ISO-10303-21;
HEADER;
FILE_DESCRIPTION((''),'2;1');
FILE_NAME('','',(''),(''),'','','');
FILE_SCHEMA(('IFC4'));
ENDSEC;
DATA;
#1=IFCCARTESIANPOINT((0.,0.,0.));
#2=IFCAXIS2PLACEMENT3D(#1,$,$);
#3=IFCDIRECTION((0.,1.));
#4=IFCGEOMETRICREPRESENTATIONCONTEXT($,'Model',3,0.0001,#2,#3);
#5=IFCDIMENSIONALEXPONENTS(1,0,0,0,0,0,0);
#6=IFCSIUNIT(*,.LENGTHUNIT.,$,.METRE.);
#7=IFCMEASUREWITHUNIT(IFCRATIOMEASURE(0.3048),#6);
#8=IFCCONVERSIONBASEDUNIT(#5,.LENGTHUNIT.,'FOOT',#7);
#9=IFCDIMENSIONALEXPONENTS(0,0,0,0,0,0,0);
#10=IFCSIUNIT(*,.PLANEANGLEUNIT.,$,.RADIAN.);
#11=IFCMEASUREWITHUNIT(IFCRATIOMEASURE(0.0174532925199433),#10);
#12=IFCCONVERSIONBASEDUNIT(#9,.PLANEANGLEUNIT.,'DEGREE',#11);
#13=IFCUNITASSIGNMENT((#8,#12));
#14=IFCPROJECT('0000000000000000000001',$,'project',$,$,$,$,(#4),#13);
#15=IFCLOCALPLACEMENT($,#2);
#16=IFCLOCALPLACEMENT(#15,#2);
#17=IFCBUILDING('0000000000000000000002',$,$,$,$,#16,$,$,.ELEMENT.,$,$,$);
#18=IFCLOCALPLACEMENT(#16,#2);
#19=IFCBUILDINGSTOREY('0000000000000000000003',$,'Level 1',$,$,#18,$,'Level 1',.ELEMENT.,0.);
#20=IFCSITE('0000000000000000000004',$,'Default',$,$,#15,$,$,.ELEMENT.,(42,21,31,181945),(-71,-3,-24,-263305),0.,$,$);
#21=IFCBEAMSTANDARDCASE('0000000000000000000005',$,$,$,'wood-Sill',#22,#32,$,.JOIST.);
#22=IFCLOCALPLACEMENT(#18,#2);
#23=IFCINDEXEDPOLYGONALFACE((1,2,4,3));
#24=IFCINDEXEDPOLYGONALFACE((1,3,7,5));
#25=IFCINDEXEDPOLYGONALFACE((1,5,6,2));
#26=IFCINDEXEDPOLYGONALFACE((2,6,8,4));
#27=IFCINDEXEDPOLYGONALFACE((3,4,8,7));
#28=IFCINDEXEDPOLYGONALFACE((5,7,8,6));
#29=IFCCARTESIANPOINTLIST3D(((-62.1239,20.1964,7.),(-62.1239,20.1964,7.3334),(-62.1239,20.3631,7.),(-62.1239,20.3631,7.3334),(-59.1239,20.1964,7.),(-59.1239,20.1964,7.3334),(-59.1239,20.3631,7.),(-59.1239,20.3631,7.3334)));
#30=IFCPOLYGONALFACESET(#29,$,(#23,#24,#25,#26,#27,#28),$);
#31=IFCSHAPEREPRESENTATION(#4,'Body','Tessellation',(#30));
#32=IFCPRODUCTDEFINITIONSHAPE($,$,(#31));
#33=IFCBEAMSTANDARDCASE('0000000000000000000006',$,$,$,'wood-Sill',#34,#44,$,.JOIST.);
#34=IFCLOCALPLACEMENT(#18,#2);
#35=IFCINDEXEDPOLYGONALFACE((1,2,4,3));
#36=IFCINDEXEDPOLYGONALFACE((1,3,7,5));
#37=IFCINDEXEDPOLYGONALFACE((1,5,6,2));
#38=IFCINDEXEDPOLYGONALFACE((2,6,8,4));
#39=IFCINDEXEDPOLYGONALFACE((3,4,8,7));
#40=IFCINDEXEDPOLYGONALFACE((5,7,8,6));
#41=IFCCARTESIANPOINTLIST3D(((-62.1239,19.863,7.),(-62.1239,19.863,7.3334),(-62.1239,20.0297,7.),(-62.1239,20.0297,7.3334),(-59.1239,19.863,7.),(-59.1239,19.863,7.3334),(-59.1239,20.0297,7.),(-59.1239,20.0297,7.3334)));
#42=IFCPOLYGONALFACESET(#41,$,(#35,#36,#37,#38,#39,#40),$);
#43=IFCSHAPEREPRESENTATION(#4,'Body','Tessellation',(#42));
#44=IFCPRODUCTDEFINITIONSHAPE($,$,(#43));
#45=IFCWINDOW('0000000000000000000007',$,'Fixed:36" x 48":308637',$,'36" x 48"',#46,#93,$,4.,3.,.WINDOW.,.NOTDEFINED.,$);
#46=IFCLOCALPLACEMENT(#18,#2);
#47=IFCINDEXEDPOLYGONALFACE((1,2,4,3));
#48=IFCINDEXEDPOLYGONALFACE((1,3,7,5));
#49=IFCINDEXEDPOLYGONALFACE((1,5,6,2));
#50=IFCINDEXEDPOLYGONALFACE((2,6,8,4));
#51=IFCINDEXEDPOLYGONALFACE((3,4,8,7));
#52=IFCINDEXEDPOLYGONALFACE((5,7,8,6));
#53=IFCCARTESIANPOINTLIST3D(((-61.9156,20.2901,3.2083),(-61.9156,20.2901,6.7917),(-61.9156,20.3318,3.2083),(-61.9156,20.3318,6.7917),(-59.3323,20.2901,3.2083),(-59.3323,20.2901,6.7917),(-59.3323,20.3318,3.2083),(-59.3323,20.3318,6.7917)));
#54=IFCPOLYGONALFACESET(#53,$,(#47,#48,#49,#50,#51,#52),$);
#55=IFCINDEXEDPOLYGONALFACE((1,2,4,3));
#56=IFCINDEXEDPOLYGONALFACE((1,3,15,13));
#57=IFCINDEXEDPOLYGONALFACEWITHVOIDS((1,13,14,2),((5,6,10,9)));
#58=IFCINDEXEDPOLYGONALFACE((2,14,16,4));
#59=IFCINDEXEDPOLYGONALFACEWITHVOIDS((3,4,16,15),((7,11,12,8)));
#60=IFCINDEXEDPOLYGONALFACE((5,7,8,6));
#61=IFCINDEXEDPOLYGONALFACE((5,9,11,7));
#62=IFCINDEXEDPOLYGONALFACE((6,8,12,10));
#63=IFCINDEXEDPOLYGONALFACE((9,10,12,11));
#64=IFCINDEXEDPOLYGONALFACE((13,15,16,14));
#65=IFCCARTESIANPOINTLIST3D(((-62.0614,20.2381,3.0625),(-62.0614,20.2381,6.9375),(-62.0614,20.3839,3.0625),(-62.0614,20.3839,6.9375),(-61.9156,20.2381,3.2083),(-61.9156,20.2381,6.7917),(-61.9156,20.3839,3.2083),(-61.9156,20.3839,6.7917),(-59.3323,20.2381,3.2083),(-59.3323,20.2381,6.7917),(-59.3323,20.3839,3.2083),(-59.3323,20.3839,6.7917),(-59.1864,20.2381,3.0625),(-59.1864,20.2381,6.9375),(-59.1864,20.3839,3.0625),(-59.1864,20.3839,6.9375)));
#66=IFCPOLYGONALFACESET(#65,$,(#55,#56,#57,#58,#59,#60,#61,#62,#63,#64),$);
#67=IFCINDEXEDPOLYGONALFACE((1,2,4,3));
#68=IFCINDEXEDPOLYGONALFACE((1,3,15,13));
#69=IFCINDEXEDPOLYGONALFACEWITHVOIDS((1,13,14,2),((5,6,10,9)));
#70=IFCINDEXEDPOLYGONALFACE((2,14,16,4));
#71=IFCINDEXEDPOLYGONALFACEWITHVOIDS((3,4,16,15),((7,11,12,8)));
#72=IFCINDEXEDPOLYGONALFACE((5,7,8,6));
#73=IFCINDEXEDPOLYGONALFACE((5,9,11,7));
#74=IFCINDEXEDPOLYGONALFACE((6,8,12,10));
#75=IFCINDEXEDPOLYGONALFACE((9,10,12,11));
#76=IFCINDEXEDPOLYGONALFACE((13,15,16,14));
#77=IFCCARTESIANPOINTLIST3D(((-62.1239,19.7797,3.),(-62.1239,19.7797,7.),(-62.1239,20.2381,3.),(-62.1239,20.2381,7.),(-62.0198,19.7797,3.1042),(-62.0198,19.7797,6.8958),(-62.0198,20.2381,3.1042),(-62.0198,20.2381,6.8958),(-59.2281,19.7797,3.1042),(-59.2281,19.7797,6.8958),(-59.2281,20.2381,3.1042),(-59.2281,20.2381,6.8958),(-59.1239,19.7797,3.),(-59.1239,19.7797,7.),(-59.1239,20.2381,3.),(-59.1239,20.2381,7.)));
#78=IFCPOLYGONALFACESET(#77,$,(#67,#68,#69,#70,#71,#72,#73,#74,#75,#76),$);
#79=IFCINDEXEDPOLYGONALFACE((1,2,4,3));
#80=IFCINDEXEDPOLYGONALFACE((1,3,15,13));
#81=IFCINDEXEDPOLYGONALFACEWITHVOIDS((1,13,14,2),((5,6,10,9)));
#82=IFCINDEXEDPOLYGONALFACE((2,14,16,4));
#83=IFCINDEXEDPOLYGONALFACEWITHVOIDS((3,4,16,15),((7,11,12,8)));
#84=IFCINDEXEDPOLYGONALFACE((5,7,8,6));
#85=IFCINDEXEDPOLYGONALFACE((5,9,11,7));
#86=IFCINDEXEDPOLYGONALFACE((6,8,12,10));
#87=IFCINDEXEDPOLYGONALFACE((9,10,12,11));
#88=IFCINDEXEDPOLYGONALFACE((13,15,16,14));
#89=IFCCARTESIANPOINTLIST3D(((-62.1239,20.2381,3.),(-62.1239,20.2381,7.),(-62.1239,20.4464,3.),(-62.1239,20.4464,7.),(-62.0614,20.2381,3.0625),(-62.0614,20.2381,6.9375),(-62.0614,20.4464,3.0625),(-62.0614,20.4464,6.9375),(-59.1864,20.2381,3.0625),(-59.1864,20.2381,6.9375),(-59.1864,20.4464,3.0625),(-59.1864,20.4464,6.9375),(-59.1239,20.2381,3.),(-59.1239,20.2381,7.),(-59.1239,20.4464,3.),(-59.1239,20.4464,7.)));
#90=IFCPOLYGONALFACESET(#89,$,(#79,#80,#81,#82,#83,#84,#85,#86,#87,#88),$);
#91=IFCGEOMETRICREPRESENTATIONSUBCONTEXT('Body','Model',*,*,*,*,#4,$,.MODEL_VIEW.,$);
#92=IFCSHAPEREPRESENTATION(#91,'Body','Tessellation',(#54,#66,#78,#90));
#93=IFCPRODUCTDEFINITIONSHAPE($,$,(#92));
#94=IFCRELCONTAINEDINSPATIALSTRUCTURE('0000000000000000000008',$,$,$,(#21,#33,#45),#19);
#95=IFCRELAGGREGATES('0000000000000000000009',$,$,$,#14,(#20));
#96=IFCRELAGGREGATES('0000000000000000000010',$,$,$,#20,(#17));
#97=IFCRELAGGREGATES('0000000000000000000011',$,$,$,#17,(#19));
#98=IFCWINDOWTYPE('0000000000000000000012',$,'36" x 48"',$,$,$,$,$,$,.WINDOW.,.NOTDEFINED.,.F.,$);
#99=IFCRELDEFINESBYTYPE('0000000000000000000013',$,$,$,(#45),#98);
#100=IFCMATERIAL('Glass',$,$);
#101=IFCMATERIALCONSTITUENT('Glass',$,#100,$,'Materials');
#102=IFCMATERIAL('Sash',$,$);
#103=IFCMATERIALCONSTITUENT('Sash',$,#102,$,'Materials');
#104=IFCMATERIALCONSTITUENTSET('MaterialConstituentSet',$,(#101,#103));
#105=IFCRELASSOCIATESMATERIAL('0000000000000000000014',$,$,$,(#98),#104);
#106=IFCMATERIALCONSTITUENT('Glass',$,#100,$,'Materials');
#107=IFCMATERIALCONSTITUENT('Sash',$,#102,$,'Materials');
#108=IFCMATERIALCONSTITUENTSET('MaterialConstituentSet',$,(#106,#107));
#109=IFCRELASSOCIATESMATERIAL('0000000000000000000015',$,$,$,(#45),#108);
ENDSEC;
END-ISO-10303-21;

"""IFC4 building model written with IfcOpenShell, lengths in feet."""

from ifc_helpers import new_model, entity, si_unit, converted_unit, direction, frame, frame_2d, origin, origin_with_axes, place, context, subcontext, project, spatial, polyline, rectangle, outline, extrude, source, transform, mapped, material, constituent, constituent_set, type_object, type_shapes, element, save


model = new_model("IFC4")

# Units and contexts
model_context = context("Model", 3, precision=0.0001, world=origin(), true_north=direction((0.0, 1.0)))
body_context = subcontext(model_context, "Body", "Model", "MODEL_VIEW")
ifc_project = project(units=[converted_unit("LENGTHUNIT", "FOOT", entity("IfcRatioMeasure", 0.3048), si_unit("LENGTHUNIT", "METRE"), dimensions=[1, 0, 0, 0, 0, 0, 0]), converted_unit("PLANEANGLEUNIT", "DEGREE", entity("IfcRatioMeasure", 0.0174532925199433), si_unit("PLANEANGLEUNIT", "RADIAN"), dimensions=[0, 0, 0, 0, 0, 0, 0])], contexts=[model_context])

# Site, building, storey
site_placement = place(None, origin())
site = spatial("IfcSite", under=ifc_project, at=site_placement, Name="Default", CompositionType="ELEMENT", RefLatitude=(42, 21, 31, 181945), RefLongitude=(-71, -3, -24, -263305), RefElevation=0.0)
building_placement = place(site_placement, origin())
building = spatial("IfcBuilding", under=site, at=building_placement, CompositionType="ELEMENT")
storey_placement = place(building_placement, origin())
storey = spatial("IfcBuildingStorey", under=building, at=storey_placement, Name="Level 1", LongName="Level 1", CompositionType="ELEMENT", Elevation=0.0)

# Shared definitions
placement_1 = place(storey_placement, frame((-69.2906, 20.1131, 0.0)))

# Beams
for number, where, z_axis, x_axis in (
    (1, (7.1667, 0.1667, 7.1667), (1.0, 0.0, 0.0), (0.0, 0.0, 1.0)),
    (2, (7.1667, -0.1667, 7.1667), (1.0, 0.0, 0.0), (0.0, 0.0, 1.0)),
):
    element("IfcBeamStandardCase", number, at=place(placement_1, frame(where, z_axis=z_axis, x_axis=x_axis)), inside=storey, ObjectType="wood-Sill", PredefinedType="JOIST", context=model_context, shape_type="SweptSolid", body=[
        extrude(rectangle(XDim=0.3333, YDim=0.1667), origin_with_axes(), (0.0, 0.0, 1.0), 3.0),
    ])

# Window
ifc_material_1 = material(Name="Glass")
ifc_constituent_1 = constituent(ifc_material_1, Name="Glass", Category="Materials")
ifc_material_2 = material(Name="Sash")
ifc_constituent_2 = constituent(ifc_material_2, Name="Sash", Category="Materials")
ifc_constituent_set_1 = constituent_set(constituents=[ifc_constituent_1, ifc_constituent_2], Name="MaterialConstituentSet")
ifc_constituent_3 = constituent(ifc_material_1, Name="Glass", Category="Materials")
ifc_constituent_4 = constituent(ifc_material_2, Name="Sash", Category="Materials")
ifc_constituent_set_2 = constituent_set(constituents=[ifc_constituent_3, ifc_constituent_4], Name="MaterialConstituentSet")
window_type = type_object("IfcWindowType", Name="36\" x 48\"", ParameterTakesPrecedence=False, PartitioningType="NOTDEFINED", PredefinedType="WINDOW", material=ifc_constituent_set_2)
shared_shape = source(origin(), body_context, "Body", "SweptSolid", [
    extrude(rectangle(XDim=0.0417, YDim=2.5833, at=frame_2d((0.0, 0.0), x_axis=(1.0, 0.0))), frame((1.5, 0.5312, 0.2083), z_axis=(0.0, 0.0, 1.0), x_axis=(0.0, 1.0, 0.0)), (0.0, 0.0, 1.0), 3.5833),
    extrude(outline(polyline([(-1.4375, -1.9375), (1.4375, -1.9375), (1.4375, 1.9375), (-1.4375, 1.9375), (-1.4375, -1.9375)]), holes=[polyline([(-1.2917, -1.7917), (-1.2917, 1.7917), (1.2917, 1.7917), (1.2917, -1.7917), (-1.2917, -1.7917)])]), frame((1.5, 0.4583, 2.0), z_axis=(0.0, 1.0, 0.0), x_axis=(1.0, 0.0, 0.0)), (0.0, 0.0, 1.0), 0.1458),
    extrude(outline(polyline([(-1.5, -2.0), (1.5, -2.0), (1.5, 2.0), (-1.5, 2.0), (-1.5, -2.0)]), holes=[polyline([(-1.3958, -1.8958), (-1.3958, 1.8958), (1.3958, 1.8958), (1.3958, -1.8958), (-1.3958, -1.8958)])]), frame((1.5, 0.0, 2.0), z_axis=(0.0, 1.0, 0.0), x_axis=(1.0, 0.0, 0.0)), (0.0, 0.0, 1.0), 0.4583),
    extrude(outline(polyline([(-2.0, -1.5), (2.0, -1.5), (2.0, 1.5), (-2.0, 1.5), (-2.0, -1.5)]), holes=[polyline([(-1.9375, -1.4375), (-1.9375, 1.4375), (1.9375, 1.4375), (1.9375, -1.4375), (-1.9375, -1.4375)])]), frame((1.5, 0.4583, 2.0), z_axis=(0.0, 1.0, 0.0), x_axis=(0.0, 0.0, -1.0)), (0.0, 0.0, 1.0), 0.2083),
])
type_shapes(window_type, [shared_shape])
placement_2 = place(placement_1, frame((7.1667, -0.3333, 3.0)))
window_placement = place(placement_2, origin())
element("IfcWindow", 3, at=window_placement, inside=storey, type_object=window_type, material=ifc_constituent_set_1, Name="Fixed:36\" x 48\":308637", ObjectType="36\" x 48\"", OverallHeight=4.0, OverallWidth=3.0, PartitioningType="NOTDEFINED", PredefinedType="WINDOW", context=body_context, shape_type="MappedRepresentation", body=[
    mapped(shared_shape, transform((0.0, 0.0, 0.0), scale=1.0)),
])

save(model, "model.ifc")
